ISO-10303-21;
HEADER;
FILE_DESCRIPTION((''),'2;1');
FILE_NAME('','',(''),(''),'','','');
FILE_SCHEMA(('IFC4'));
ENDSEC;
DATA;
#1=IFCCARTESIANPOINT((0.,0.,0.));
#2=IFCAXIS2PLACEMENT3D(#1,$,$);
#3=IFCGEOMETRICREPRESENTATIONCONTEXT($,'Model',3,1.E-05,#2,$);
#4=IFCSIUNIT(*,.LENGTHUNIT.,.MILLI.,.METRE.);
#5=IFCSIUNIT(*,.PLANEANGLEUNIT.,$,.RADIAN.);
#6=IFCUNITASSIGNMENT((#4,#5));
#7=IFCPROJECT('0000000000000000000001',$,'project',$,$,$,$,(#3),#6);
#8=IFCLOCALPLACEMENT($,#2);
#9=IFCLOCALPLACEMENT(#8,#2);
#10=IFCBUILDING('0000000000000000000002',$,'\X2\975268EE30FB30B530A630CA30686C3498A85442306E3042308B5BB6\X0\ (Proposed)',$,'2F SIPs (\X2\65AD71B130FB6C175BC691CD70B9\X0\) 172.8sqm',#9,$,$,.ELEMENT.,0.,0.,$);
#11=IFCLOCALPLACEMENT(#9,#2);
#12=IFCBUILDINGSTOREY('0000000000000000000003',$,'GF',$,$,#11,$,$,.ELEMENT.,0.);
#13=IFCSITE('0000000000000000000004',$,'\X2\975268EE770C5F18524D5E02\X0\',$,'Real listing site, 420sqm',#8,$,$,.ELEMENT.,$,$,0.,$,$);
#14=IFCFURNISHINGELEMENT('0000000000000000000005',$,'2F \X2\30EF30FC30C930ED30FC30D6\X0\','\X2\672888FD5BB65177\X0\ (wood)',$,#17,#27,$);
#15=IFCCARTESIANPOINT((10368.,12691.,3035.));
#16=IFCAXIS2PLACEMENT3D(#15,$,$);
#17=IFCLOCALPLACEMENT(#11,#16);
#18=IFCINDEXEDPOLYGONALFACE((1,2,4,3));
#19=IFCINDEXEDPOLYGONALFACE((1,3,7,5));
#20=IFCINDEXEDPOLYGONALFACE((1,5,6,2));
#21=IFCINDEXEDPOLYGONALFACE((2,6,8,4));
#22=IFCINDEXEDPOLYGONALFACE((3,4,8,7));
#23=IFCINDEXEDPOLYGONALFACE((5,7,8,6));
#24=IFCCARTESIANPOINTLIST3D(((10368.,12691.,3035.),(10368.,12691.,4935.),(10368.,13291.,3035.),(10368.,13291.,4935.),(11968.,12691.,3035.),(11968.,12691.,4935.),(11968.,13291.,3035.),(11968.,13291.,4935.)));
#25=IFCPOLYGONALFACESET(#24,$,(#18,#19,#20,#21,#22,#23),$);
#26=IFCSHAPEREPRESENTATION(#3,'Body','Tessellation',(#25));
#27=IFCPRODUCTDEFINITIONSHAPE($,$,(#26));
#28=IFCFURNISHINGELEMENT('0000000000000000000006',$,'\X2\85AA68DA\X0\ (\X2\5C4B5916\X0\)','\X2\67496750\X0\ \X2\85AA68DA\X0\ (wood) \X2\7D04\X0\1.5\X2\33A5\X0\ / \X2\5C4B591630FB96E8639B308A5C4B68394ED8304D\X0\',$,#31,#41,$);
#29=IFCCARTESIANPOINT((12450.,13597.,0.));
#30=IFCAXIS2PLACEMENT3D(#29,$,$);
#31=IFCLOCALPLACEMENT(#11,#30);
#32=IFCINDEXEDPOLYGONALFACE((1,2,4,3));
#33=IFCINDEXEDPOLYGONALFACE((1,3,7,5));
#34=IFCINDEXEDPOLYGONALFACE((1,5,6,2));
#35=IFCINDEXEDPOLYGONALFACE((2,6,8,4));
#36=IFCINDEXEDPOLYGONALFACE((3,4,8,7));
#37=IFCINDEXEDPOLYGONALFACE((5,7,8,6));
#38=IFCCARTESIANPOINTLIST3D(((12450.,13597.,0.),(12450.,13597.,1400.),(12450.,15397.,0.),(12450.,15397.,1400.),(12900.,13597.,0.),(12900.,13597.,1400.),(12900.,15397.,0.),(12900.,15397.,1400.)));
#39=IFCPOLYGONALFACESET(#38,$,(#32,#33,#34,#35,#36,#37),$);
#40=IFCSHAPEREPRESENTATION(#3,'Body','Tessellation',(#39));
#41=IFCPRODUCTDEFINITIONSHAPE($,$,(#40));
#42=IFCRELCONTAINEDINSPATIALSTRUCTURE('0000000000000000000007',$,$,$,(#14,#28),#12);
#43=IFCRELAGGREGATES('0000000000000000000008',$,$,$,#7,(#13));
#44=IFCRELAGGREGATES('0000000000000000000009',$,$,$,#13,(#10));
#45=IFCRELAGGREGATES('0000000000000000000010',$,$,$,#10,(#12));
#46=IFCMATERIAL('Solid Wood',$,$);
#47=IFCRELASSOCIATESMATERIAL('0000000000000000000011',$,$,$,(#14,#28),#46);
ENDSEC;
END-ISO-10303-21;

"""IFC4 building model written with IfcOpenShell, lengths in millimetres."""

from ifc_helpers import new_model, si_unit, frame, frame_2d, origin, place, context, project, spatial, rectangle, extrude, material, element, save


model = new_model("IFC4")

# Units and contexts
model_context = context("Model", 3, precision=1e-05, world=origin())
ifc_project = project(units=[si_unit("LENGTHUNIT", "METRE", prefix="MILLI"), si_unit("PLANEANGLEUNIT", "RADIAN")], contexts=[model_context])

# Site, building, storey
site_placement = place(None, origin())
site = spatial("IfcSite", under=ifc_project, at=site_placement, Name="青森県弘前市", ObjectType="Real listing site, 420sqm", CompositionType="ELEMENT", RefElevation=0.0)
building_placement = place(site_placement, origin())
building = spatial("IfcBuilding", under=site, at=building_placement, Name="青森・サウナと水風呂のある家 (Proposed)", ObjectType="2F SIPs (断熱・気密重点) 172.8sqm", CompositionType="ELEMENT", ElevationOfRefHeight=0.0, ElevationOfTerrain=0.0)
storey_placement = place(building_placement, origin())
storey = spatial("IfcBuildingStorey", under=building, at=storey_placement, Name="GF", CompositionType="ELEMENT", Elevation=0.0)

# Shared definitions
ifc_material_1 = material(Name="Solid Wood")

# Furnishing elements
furnishing_1_placement = place(storey_placement, frame((10368.0, 12691.0, 3035.0)))
element("IfcFurnishingElement", 1, at=furnishing_1_placement, inside=storey, material=ifc_material_1, Name="2F ワードローブ", Description="木製家具 (wood)", context=model_context, shape_type="SweptSolid", body=[
    extrude(rectangle(XDim=1600.0, YDim=600.0, at=frame_2d((800.0, 300.0))), frame((10368.0, 12691.0, 3035.0)), (0.0, 0.0, 1.0), 1900.0),
])
furnishing_2_placement = place(storey_placement, frame((12450.0, 13597.0, 0.0)))
element("IfcFurnishingElement", 2, at=furnishing_2_placement, inside=storey, material=ifc_material_1, Name="薪棚 (屋外)", Description="杉材 薪棚 (wood) 約1.5㎥ / 屋外・雨掛り屋根付き", context=model_context, shape_type="SweptSolid", body=[
    extrude(rectangle(XDim=450.0, YDim=1800.0, at=frame_2d((225.0, 900.0))), frame((12450.0, 13597.0, 0.0)), (0.0, 0.0, 1.0), 1400.0),
])

save(model, "model.ifc")
